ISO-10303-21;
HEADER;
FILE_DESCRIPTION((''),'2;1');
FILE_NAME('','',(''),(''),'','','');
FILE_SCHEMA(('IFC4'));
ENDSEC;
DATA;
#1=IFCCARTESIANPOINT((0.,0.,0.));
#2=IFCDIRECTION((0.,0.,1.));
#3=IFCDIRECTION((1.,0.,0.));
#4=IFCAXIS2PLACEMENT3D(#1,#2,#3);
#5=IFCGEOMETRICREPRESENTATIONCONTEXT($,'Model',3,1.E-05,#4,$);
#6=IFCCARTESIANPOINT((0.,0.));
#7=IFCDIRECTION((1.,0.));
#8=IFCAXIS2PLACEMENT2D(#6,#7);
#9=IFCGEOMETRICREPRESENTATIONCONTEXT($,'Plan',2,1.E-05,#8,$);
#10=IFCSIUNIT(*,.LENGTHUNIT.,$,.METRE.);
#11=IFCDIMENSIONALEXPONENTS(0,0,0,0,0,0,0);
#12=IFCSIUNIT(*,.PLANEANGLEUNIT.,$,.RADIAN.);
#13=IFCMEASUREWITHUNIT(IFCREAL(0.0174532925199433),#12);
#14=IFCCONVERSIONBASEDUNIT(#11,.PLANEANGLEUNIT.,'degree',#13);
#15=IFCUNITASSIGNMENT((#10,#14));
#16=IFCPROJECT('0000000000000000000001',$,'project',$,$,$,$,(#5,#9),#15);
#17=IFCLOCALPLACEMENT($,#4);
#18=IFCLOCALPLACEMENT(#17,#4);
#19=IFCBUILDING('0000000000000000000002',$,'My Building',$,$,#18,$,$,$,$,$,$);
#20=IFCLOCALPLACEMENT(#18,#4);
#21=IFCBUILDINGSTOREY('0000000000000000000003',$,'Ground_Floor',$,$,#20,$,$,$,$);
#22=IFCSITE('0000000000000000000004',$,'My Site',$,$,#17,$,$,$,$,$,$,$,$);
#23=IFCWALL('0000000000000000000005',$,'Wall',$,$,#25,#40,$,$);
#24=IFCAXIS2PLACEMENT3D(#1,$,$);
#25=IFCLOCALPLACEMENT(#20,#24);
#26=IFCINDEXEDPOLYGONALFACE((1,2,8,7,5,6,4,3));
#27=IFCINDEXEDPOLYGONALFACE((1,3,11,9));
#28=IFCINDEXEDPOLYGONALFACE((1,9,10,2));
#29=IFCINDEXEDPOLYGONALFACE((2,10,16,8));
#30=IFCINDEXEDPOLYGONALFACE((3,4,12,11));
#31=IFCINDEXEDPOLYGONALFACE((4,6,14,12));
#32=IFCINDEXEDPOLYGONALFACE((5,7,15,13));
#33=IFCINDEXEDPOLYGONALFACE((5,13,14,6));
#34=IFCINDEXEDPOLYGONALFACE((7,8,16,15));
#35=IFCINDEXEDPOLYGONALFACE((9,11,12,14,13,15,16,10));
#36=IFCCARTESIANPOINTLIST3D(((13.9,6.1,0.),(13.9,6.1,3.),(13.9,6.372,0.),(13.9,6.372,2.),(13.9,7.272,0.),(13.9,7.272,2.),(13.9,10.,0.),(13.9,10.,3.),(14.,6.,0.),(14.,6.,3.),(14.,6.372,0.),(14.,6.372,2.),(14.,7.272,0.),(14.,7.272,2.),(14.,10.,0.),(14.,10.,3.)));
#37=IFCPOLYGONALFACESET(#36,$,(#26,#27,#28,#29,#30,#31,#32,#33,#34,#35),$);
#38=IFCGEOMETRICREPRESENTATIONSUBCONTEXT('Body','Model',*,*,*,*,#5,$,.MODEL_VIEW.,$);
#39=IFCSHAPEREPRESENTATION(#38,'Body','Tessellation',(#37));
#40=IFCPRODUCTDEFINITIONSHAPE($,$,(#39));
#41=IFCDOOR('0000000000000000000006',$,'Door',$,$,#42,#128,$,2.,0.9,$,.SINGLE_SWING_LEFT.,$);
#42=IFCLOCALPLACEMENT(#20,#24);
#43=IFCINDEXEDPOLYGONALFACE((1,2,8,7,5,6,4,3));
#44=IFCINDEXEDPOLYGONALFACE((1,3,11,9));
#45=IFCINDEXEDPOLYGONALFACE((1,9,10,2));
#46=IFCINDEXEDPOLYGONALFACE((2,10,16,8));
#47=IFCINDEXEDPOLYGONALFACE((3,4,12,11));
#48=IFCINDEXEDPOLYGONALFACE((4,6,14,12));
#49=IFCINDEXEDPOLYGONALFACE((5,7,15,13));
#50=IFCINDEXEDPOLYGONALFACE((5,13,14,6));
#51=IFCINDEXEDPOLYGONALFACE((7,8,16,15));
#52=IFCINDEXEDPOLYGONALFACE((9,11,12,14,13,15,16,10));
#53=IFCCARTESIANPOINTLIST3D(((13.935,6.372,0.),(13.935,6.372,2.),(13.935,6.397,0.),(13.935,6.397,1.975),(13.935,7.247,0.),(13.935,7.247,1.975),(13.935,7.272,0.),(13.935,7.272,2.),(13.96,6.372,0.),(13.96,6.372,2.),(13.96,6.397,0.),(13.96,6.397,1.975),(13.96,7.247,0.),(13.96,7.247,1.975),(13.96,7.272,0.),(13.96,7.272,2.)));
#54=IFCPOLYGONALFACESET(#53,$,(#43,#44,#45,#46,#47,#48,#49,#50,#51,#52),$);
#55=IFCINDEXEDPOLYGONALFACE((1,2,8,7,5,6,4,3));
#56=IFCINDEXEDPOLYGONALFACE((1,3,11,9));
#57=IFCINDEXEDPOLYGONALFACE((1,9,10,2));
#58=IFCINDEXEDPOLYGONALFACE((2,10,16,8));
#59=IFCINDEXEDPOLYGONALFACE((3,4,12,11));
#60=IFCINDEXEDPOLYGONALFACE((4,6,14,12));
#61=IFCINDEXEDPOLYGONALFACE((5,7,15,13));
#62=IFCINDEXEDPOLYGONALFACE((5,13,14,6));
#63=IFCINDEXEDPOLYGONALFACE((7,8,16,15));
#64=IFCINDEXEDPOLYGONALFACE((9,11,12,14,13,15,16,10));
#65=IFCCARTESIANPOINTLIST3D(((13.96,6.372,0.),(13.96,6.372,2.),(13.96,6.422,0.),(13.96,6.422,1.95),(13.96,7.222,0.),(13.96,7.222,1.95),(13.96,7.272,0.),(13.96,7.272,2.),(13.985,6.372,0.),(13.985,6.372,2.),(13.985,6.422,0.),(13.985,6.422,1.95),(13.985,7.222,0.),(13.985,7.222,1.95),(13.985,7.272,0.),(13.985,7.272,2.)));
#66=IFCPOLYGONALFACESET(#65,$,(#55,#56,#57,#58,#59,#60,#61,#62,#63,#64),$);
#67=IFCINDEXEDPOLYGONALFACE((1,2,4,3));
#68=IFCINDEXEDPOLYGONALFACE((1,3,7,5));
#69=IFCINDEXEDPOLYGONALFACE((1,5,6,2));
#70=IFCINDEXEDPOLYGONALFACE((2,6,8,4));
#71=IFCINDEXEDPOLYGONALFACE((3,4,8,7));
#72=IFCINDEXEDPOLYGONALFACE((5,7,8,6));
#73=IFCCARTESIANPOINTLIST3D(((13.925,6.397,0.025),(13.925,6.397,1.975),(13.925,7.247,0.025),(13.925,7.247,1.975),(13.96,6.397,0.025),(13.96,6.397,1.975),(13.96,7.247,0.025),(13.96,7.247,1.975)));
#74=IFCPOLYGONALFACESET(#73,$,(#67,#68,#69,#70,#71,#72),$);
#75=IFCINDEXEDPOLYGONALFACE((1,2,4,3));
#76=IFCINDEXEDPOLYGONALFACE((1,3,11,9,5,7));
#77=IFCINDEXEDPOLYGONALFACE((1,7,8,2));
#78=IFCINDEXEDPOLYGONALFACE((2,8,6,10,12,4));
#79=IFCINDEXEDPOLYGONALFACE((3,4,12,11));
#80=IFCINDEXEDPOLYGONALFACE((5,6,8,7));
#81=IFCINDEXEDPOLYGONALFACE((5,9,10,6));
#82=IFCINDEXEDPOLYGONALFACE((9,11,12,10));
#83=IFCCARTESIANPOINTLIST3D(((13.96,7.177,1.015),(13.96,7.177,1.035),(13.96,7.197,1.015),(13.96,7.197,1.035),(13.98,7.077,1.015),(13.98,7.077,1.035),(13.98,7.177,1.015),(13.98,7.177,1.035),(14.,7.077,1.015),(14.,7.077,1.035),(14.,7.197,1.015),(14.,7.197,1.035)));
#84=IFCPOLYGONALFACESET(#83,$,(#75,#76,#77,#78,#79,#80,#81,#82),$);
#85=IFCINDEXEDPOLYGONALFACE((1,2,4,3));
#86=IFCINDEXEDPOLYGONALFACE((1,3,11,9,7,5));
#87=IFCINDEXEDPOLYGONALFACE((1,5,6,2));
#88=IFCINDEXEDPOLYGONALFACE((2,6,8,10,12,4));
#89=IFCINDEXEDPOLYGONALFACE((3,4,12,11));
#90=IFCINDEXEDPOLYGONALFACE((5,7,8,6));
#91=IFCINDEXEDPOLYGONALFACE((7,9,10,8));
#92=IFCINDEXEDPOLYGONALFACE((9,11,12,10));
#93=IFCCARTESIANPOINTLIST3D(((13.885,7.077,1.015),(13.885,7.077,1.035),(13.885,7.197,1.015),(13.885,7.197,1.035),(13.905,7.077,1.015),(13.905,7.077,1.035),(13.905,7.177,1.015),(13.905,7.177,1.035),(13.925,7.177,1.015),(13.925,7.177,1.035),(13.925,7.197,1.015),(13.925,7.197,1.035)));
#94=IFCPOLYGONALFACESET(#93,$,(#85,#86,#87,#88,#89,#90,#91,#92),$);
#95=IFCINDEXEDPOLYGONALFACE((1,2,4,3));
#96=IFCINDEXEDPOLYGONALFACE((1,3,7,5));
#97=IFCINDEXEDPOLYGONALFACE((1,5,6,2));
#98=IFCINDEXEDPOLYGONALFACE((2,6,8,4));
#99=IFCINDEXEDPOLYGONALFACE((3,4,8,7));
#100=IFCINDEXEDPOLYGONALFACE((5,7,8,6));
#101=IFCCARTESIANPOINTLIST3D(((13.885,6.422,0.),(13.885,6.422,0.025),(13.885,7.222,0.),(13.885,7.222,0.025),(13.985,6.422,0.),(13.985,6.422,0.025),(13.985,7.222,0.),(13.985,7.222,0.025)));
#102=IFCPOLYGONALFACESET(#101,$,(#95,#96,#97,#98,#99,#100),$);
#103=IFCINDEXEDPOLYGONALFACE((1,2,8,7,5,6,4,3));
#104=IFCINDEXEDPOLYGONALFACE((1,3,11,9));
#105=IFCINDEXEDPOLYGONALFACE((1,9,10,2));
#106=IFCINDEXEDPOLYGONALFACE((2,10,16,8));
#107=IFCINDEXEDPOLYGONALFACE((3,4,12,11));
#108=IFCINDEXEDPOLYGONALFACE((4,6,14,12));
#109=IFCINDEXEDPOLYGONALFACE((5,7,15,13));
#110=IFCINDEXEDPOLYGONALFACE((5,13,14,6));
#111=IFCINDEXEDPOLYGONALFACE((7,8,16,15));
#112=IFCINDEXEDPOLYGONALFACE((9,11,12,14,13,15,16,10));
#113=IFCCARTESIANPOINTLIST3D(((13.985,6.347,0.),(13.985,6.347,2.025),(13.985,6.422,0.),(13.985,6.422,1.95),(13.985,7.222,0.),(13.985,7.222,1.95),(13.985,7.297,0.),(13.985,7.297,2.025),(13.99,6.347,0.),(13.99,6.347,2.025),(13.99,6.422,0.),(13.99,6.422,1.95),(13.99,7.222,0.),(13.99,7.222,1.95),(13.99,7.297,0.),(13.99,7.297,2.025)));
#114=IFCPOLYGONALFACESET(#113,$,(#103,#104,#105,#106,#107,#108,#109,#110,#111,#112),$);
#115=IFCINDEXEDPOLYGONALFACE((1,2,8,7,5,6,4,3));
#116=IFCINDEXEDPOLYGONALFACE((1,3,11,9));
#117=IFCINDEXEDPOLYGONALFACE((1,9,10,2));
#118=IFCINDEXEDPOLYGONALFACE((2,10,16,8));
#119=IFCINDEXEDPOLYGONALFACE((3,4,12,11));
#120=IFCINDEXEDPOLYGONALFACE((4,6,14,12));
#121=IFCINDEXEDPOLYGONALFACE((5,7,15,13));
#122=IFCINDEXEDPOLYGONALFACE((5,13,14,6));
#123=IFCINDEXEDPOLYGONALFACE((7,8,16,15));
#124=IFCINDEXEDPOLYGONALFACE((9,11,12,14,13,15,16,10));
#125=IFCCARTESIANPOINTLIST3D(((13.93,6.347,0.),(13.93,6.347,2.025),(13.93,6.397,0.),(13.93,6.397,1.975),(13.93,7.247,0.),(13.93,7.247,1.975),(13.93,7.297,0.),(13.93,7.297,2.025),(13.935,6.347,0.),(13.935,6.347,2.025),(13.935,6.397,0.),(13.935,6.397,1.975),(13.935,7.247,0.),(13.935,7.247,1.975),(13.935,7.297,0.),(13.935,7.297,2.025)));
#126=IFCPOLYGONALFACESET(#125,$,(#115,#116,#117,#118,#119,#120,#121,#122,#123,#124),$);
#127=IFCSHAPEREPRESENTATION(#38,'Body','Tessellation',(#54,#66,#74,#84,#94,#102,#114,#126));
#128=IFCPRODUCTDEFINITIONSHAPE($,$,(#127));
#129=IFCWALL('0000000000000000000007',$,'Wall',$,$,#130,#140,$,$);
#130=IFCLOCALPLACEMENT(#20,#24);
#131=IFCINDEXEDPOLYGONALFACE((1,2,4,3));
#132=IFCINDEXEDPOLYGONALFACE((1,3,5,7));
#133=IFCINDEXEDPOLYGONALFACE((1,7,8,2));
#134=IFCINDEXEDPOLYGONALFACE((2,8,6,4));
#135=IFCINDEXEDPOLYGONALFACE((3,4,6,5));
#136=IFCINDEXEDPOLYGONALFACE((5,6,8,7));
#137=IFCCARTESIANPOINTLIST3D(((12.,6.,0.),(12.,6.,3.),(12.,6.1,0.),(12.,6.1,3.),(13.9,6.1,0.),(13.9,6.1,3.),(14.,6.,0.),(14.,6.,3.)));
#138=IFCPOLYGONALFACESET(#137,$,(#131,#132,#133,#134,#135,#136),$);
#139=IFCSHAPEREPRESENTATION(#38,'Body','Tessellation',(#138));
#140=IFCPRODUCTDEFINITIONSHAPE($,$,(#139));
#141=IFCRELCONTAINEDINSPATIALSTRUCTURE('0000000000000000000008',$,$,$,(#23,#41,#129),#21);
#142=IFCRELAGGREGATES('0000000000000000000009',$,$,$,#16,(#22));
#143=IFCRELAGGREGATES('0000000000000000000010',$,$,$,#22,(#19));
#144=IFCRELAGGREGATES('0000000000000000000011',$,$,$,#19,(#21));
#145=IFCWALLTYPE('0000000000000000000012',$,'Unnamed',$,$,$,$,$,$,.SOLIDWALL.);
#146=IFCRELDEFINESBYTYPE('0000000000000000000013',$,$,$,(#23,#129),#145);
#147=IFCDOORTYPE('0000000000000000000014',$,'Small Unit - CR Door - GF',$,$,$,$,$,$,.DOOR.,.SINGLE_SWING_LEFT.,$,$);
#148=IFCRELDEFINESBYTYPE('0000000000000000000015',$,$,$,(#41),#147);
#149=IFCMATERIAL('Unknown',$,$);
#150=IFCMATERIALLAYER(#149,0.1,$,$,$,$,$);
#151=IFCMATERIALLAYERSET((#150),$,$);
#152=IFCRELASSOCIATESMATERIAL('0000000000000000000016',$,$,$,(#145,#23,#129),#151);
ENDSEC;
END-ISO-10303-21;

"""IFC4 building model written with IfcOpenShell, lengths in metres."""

from ifc_helpers import new_model, entity, si_unit, converted_unit, frame, origin_with_axes, origin_2d_with_axis, place, context, subcontext, project, spatial, line, indexed_curve, outline, extrude, shape, source, transform, mapped, material, layer, layer_set, layer_usage, type_object, type_shapes, element, fill, save


model = new_model("IFC4")

# Units and contexts
model_context = context("Model", 3, precision=1e-05, world=origin_with_axes())
plan_context = context("Plan", 2, precision=1e-05, world=origin_2d_with_axis())
body_context_1 = subcontext(model_context, "Body", "Model", "MODEL_VIEW")
body_context_2 = subcontext(plan_context, "Body", "Plan", "PLAN_VIEW")
ifc_project = project(units=[si_unit("LENGTHUNIT", "METRE"), converted_unit("PLANEANGLEUNIT", "degree", entity("IfcReal", 0.0174532925199433), si_unit("PLANEANGLEUNIT", "RADIAN"), dimensions=[0, 0, 0, 0, 0, 0, 0])], contexts=[model_context, plan_context])

# Site, building, storey
site_placement = place(None, origin_with_axes())
site = spatial("IfcSite", under=ifc_project, at=site_placement, Name="My Site")
building_placement = place(site_placement, origin_with_axes())
building = spatial("IfcBuilding", under=site, at=building_placement, Name="My Building")
storey_placement = place(building_placement, origin_with_axes())
storey = spatial("IfcBuildingStorey", under=building, at=storey_placement, Name="Ground_Floor")

# Shared definitions
ifc_material = material(Name="Unknown")
ifc_layer = layer(ifc_material, 0.1)
ifc_layer_set = layer_set([ifc_layer])
wall_type = type_object("IfcWallType", Name="Unnamed", PredefinedType="SOLIDWALL", material=ifc_layer_set)

# Shared definitions
shared_shape_1 = source(origin_with_axes(), body_context_1, "Body", "SweptSolid", [
    extrude(outline(indexed_curve([(0.0, 0.0), (0.9, 0.0), (0.9, 2.0), (0.0, 2.0)], segments=[line(1, 2, 3, 4, 1)])), frame((0.0, -0.6, 0.0), z_axis=(0.0, -1.0, 0.0), x_axis=(1.0, 0.0, 0.0)), (0.0, 0.0, -1.0), 1.2),
])
door_type_1 = type_object("IfcDoorType", Name="Small Unit - CR Door - GF", OperationType="SINGLE_SWING_LEFT", PredefinedType="DOOR")
shared_shape_2 = source(origin_with_axes(), body_context_1, "Body", "SweptSolid", [
    extrude(outline(indexed_curve([(0.0, 0.0), (0.0, 2.0), (0.9, 2.0), (0.9, 0.0), (0.875, 0.0), (0.875, 1.975), (0.025, 1.975), (0.025, 0.0)], segments=[line(1, 2, 3, 4, 5, 6, 7, 8, 1)])), frame((0.0, 0.025, 0.0), z_axis=(0.0, -1.0, 0.0), x_axis=(1.0, 0.0, 0.0)), (0.0, 0.0, -1.0), 0.025),
    extrude(outline(indexed_curve([(0.0, 0.0), (0.0, 2.0), (0.9, 2.0), (0.9, 0.0), (0.85, 0.0), (0.85, 1.95), (0.05, 1.95), (0.05, 0.0)], segments=[line(1, 2, 3, 4, 5, 6, 7, 8, 1)])), frame((0.0, 0.0, 0.0), z_axis=(0.0, -1.0, 0.0), x_axis=(1.0, 0.0, 0.0)), (0.0, 0.0, -1.0), 0.025),
    extrude(outline(indexed_curve([(0.0, 0.0), (0.85, 0.0), (0.85, 0.035), (0.0, 0.035)], segments=[line(1, 2, 3, 4, 1)])), frame((0.025, 0.025, 0.025), z_axis=(0.0, 0.0, 1.0), x_axis=(1.0, 0.0, 0.0)), (0.0, 0.0, 1.0), 1.95),
    extrude(outline(indexed_curve([(0.0, 0.0), (0.0, -0.04), (-0.12, -0.04), (-0.12, -0.02), (-0.02, -0.02), (-0.02, 0.0)], segments=[line(1, 2, 3, 4, 5, 6, 1)])), frame((0.825, 0.025, 1.015), z_axis=(0.0, 0.0, 1.0), x_axis=(1.0, 0.0, 0.0)), (0.0, 0.0, 1.0), 0.02),
    extrude(outline(indexed_curve([(0.0, 0.0), (0.0, 0.04), (-0.12, 0.04), (-0.12, 0.02), (-0.02, 0.02), (-0.02, 0.0)], segments=[line(1, 2, 3, 4, 5, 6, 1)])), frame((0.825, 0.06, 1.015), z_axis=(0.0, 0.0, 1.0), x_axis=(1.0, 0.0, 0.0)), (0.0, 0.0, 1.0), 0.02),
    extrude(outline(indexed_curve([(0.0, 0.0), (0.8, 0.0), (0.8, 0.1), (0.0, 0.1)], segments=[line(1, 2, 3, 4, 1)])), frame((0.05, 0.0, 0.0), z_axis=(0.0, 0.0, 1.0), x_axis=(1.0, 0.0, 0.0)), (0.0, 0.0, 1.0), 0.025),
    extrude(outline(indexed_curve([(0.0, 0.0), (0.0, 2.025), (0.95, 2.025), (0.95, 0.0), (0.875, 0.0), (0.875, 1.95), (0.075, 1.95), (0.075, 0.0)], segments=[line(1, 2, 3, 4, 5, 6, 7, 8, 1)])), frame((-0.025, -0.005, 0.0), z_axis=(0.0, -1.0, 0.0), x_axis=(1.0, 0.0, 0.0)), (0.0, 0.0, -1.0), 0.005),
    extrude(outline(indexed_curve([(0.0, 0.0), (0.0, 2.025), (0.95, 2.025), (0.95, 0.0), (0.9, 0.0), (0.9, 1.975), (0.05, 1.975), (0.05, 0.0)], segments=[line(1, 2, 3, 4, 5, 6, 7, 8, 1)])), frame((-0.025, 0.05, 0.0), z_axis=(0.0, -1.0, 0.0), x_axis=(1.0, 0.0, 0.0)), (0.0, 0.0, -1.0), 0.005),
])
shared_shape_3 = source(origin_with_axes(), body_context_2, "Body", "Curve2D", [
    entity("IfcIndexedPolyCurve", entity("IfcCartesianPointList2D", [[0.0, 0.0], [0.0, 0.05], [0.025, 0.05], [0.025, 0.025], [0.05, 0.025], [0.05, 0.0]]), [entity("IfcLineIndex", [1, 2, 3, 4, 5, 6, 1])]),
    entity("IfcIndexedPolyCurve", entity("IfcCartesianPointList2D", [[0.9, 0.0], [0.9, 0.05], [0.875, 0.05], [0.875, 0.025], [0.85, 0.025], [0.85, 0.0]]), [entity("IfcLineIndex", [1, 2, 3, 4, 5, 6, 1])]),
    entity("IfcTrimmedCurve", entity("IfcEllipse", entity("IfcAxis2Placement2D", entity("IfcCartesianPoint", [0.06, 0.05]), entity("IfcDirection", [1.0, 0.0])), 0.815, 0.85), [entity("IfcCartesianPoint", [0.875, 0.05])], [entity("IfcCartesianPoint", [0.06, 0.9])], True, "CARTESIAN"),
    entity("IfcIndexedPolyCurve", entity("IfcCartesianPointList2D", [[0.025, 0.05], [0.06, 0.05], [0.06, 0.9], [0.025, 0.9]]), [entity("IfcLineIndex", [1, 2, 3, 4, 1])]),
])
type_shapes(door_type_1, [shared_shape_2, shared_shape_3])

# Wall, opening, door
ifc_layer_usage_1 = layer_usage(ifc_layer_set, "AXIS2", "POSITIVE", 0.0)
wall_1_placement = place(storey_placement, frame((14.0, 6.0, 0.0), z_axis=(0.0, 0.0, 1.0), x_axis=(0.0, 1.0, 0.0)))
wall_1 = element("IfcWall", 1, at=wall_1_placement, inside=storey, type_object=wall_type, material=ifc_layer_usage_1, Name="Wall", context=body_context_1, shape_type="SweptSolid", body=[
    extrude(outline(indexed_curve([(0.0, 0.0), (0.1, 0.1), (4.0, 0.1), (4.0, 0.0)], segments=[line(1, 2, 3, 4, 1)])), origin_with_axes(), (0.0, 0.0, 1.0), 3.0),
])
opening_1_placement = place(wall_1_placement, frame((0.372, 0.015, 0.0), z_axis=(0.0, 0.0, 1.0), x_axis=(1.0, 0.0, 0.0)))
opening_1 = element("IfcOpeningElement", 2, at=opening_1_placement, cuts=wall_1, PredefinedType="OPENING", context=body_context_1, shape_type="MappedRepresentation", body=[
    mapped(shared_shape_1, transform((0.0, 0.0, 0.0), x_axis=(1.0, 0.0, 0.0), y_axis=(0.0, 1.0, 0.0), z_axis=(0.0, 0.0, 1.0), scale=1.0)),
])
door_1_placement = place(opening_1_placement, origin_with_axes())
door_1 = element("IfcDoor", 3, at=door_1_placement, inside=storey, type_object=door_type_1, Name="Door", OperationType="SINGLE_SWING_LEFT", OverallHeight=2.0, OverallWidth=0.9, shapes=[
    shape(body_context_1, "Body", "MappedRepresentation", [mapped(shared_shape_2, transform((0.0, 0.0, 0.0), x_axis=(1.0, 0.0, 0.0), y_axis=(0.0, 1.0, 0.0), z_axis=(0.0, 0.0, 1.0), scale=1.0))]),
    shape(body_context_2, "Body", "MappedRepresentation", [mapped(shared_shape_3, transform((0.0, 0.0, 0.0), x_axis=(1.0, 0.0, 0.0), y_axis=(0.0, 1.0, 0.0), z_axis=(0.0, 0.0, 1.0), scale=1.0))]),
])
fill(opening_1, door_1)

# Wall
ifc_layer_usage_2 = layer_usage(ifc_layer_set, "AXIS2", "POSITIVE", 0.0)
wall_2_placement = place(storey_placement, frame((12.0, 6.0, 0.0), z_axis=(0.0, 0.0, 1.0), x_axis=(1.0, 0.0, 0.0)))
element("IfcWall", 4, at=wall_2_placement, inside=storey, type_object=wall_type, material=ifc_layer_usage_2, Name="Wall", context=body_context_1, shape_type="SweptSolid", body=[
    extrude(outline(indexed_curve([(0.0, 0.0), (0.0, 0.1), (1.9, 0.1), (2.0, 0.0)], segments=[line(1, 2, 3, 4, 1)])), origin_with_axes(), (0.0, 0.0, 1.0), 3.0),
])

save(model, "model.ifc")
